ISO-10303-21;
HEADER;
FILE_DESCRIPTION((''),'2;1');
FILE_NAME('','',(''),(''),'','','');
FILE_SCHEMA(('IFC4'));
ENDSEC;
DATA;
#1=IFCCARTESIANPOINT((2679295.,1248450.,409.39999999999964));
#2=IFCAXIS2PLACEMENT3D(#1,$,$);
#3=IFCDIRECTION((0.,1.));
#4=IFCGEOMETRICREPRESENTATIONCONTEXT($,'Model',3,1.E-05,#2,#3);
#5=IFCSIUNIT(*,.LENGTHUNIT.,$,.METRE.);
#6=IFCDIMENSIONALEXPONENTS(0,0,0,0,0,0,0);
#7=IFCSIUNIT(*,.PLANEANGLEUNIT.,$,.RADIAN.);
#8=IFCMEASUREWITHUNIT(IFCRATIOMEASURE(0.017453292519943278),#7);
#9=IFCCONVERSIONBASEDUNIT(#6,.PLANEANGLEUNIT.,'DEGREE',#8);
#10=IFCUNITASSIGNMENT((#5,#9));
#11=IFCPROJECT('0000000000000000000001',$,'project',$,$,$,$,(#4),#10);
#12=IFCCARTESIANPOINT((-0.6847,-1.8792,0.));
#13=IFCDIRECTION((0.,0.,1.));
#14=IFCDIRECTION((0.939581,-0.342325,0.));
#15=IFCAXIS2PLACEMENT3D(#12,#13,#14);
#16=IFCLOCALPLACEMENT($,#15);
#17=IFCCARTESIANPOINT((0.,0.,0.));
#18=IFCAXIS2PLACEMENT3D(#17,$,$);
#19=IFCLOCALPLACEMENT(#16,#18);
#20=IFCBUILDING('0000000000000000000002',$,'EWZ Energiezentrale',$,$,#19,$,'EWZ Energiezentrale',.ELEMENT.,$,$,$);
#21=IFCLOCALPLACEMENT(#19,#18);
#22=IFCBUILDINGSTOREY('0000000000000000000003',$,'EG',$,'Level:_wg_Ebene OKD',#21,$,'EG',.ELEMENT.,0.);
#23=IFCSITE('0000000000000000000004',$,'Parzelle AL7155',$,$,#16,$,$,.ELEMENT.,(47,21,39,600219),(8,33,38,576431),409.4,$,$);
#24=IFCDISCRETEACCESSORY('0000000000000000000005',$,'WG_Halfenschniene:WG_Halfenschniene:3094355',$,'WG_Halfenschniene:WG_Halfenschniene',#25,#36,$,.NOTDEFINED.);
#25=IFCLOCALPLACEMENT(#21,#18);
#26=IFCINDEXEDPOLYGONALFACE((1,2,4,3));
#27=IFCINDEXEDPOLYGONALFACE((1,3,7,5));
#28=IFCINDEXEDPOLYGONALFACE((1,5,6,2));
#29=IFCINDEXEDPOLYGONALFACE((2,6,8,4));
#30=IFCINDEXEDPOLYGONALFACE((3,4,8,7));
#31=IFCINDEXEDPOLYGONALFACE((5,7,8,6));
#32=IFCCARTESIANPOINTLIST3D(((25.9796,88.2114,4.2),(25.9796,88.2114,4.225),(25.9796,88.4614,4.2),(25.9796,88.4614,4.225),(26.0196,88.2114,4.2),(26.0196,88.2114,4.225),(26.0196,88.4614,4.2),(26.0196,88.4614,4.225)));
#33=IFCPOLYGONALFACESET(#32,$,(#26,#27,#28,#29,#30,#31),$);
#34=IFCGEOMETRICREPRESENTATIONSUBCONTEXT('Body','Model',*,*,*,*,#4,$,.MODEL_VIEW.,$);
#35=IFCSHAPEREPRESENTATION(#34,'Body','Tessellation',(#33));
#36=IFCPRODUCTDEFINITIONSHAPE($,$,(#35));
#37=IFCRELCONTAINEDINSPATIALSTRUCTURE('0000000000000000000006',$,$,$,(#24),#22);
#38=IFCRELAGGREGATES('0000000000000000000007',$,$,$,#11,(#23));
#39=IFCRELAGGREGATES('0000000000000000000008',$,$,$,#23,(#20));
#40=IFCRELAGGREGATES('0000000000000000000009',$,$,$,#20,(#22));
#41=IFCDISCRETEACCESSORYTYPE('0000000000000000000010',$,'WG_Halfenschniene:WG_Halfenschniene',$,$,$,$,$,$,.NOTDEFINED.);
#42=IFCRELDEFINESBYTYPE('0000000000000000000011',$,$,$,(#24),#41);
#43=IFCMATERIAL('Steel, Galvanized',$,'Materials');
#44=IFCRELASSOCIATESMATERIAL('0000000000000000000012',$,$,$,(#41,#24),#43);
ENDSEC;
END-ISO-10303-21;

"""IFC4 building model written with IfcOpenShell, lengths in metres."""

from ifc_helpers import new_model, entity, si_unit, converted_unit, direction, frame, origin, place, context, subcontext, project, spatial, indexed_curve, outline, extrude, source, transform, mapped, material, type_object, element, save


model = new_model("IFC4")

# Units and contexts
model_context = context("Model", 3, precision=1e-05, world=frame((2679295.0, 1248450.0, 409.39999999999964)), true_north=direction((0.0, 1.0)))
body_context = subcontext(model_context, "Body", "Model", "MODEL_VIEW")
ifc_project = project(units=[si_unit("LENGTHUNIT", "METRE"), converted_unit("PLANEANGLEUNIT", "DEGREE", entity("IfcRatioMeasure", 0.017453292519943278), si_unit("PLANEANGLEUNIT", "RADIAN"), dimensions=[0, 0, 0, 0, 0, 0, 0])], contexts=[model_context])

# Site, building, storey
site_placement = place(None, frame((-0.6847, -1.8792, 0.0), z_axis=(0.0, 0.0, 1.0), x_axis=(0.939581, -0.342325, 0.0)))
site = spatial("IfcSite", under=ifc_project, at=site_placement, Name="Parzelle AL7155", CompositionType="ELEMENT", RefLatitude=(47, 21, 39, 600219), RefLongitude=(8, 33, 38, 576431), RefElevation=409.4)
building_placement = place(site_placement, origin())
building = spatial("IfcBuilding", under=site, at=building_placement, Name="EWZ Energiezentrale", LongName="EWZ Energiezentrale", CompositionType="ELEMENT")
storey_placement = place(building_placement, origin())
storey = spatial("IfcBuildingStorey", under=building, at=storey_placement, Name="EG", ObjectType="Level:_wg_Ebene OKD", LongName="EG", CompositionType="ELEMENT", Elevation=0.0)

# Discrete accessory
ifc_material = material(Name="Steel, Galvanized", Category="Materials")
discrete_accessory_type = type_object("IfcDiscreteAccessoryType", Name="WG_Halfenschniene:WG_Halfenschniene", PredefinedType="NOTDEFINED", material=ifc_material)
shared_shape = source(origin(), body_context, "Body", "SweptSolid", [
    extrude(outline(indexed_curve([(-0.125, -0.02), (0.125, -0.02), (0.125, 0.02), (-0.125, 0.02), (-0.125, -0.02)], self_intersect=False)), frame((0.125, 0.0, -0.0125)), (0.0, 0.0, 1.0), 0.025),
])
for number, where, z_axis, x_axis, name in (
    (1, (25.9996, 88.2114, 4.2125), (0.0, 0.0, -1.0), (0.0, 1.0, 0.0), "WG_Halfenschniene:WG_Halfenschniene:3094355"),
):
    element("IfcDiscreteAccessory", number, at=place(storey_placement, frame(where, z_axis=z_axis, x_axis=x_axis)), inside=storey, type_object=discrete_accessory_type, material=ifc_material, Name=name, ObjectType="WG_Halfenschniene:WG_Halfenschniene", PredefinedType="NOTDEFINED", context=body_context, shape_type="MappedRepresentation", body=[
        mapped(shared_shape, transform((0.0, 0.0, 0.0), scale=1.0)),
    ])

save(model, "model.ifc")
